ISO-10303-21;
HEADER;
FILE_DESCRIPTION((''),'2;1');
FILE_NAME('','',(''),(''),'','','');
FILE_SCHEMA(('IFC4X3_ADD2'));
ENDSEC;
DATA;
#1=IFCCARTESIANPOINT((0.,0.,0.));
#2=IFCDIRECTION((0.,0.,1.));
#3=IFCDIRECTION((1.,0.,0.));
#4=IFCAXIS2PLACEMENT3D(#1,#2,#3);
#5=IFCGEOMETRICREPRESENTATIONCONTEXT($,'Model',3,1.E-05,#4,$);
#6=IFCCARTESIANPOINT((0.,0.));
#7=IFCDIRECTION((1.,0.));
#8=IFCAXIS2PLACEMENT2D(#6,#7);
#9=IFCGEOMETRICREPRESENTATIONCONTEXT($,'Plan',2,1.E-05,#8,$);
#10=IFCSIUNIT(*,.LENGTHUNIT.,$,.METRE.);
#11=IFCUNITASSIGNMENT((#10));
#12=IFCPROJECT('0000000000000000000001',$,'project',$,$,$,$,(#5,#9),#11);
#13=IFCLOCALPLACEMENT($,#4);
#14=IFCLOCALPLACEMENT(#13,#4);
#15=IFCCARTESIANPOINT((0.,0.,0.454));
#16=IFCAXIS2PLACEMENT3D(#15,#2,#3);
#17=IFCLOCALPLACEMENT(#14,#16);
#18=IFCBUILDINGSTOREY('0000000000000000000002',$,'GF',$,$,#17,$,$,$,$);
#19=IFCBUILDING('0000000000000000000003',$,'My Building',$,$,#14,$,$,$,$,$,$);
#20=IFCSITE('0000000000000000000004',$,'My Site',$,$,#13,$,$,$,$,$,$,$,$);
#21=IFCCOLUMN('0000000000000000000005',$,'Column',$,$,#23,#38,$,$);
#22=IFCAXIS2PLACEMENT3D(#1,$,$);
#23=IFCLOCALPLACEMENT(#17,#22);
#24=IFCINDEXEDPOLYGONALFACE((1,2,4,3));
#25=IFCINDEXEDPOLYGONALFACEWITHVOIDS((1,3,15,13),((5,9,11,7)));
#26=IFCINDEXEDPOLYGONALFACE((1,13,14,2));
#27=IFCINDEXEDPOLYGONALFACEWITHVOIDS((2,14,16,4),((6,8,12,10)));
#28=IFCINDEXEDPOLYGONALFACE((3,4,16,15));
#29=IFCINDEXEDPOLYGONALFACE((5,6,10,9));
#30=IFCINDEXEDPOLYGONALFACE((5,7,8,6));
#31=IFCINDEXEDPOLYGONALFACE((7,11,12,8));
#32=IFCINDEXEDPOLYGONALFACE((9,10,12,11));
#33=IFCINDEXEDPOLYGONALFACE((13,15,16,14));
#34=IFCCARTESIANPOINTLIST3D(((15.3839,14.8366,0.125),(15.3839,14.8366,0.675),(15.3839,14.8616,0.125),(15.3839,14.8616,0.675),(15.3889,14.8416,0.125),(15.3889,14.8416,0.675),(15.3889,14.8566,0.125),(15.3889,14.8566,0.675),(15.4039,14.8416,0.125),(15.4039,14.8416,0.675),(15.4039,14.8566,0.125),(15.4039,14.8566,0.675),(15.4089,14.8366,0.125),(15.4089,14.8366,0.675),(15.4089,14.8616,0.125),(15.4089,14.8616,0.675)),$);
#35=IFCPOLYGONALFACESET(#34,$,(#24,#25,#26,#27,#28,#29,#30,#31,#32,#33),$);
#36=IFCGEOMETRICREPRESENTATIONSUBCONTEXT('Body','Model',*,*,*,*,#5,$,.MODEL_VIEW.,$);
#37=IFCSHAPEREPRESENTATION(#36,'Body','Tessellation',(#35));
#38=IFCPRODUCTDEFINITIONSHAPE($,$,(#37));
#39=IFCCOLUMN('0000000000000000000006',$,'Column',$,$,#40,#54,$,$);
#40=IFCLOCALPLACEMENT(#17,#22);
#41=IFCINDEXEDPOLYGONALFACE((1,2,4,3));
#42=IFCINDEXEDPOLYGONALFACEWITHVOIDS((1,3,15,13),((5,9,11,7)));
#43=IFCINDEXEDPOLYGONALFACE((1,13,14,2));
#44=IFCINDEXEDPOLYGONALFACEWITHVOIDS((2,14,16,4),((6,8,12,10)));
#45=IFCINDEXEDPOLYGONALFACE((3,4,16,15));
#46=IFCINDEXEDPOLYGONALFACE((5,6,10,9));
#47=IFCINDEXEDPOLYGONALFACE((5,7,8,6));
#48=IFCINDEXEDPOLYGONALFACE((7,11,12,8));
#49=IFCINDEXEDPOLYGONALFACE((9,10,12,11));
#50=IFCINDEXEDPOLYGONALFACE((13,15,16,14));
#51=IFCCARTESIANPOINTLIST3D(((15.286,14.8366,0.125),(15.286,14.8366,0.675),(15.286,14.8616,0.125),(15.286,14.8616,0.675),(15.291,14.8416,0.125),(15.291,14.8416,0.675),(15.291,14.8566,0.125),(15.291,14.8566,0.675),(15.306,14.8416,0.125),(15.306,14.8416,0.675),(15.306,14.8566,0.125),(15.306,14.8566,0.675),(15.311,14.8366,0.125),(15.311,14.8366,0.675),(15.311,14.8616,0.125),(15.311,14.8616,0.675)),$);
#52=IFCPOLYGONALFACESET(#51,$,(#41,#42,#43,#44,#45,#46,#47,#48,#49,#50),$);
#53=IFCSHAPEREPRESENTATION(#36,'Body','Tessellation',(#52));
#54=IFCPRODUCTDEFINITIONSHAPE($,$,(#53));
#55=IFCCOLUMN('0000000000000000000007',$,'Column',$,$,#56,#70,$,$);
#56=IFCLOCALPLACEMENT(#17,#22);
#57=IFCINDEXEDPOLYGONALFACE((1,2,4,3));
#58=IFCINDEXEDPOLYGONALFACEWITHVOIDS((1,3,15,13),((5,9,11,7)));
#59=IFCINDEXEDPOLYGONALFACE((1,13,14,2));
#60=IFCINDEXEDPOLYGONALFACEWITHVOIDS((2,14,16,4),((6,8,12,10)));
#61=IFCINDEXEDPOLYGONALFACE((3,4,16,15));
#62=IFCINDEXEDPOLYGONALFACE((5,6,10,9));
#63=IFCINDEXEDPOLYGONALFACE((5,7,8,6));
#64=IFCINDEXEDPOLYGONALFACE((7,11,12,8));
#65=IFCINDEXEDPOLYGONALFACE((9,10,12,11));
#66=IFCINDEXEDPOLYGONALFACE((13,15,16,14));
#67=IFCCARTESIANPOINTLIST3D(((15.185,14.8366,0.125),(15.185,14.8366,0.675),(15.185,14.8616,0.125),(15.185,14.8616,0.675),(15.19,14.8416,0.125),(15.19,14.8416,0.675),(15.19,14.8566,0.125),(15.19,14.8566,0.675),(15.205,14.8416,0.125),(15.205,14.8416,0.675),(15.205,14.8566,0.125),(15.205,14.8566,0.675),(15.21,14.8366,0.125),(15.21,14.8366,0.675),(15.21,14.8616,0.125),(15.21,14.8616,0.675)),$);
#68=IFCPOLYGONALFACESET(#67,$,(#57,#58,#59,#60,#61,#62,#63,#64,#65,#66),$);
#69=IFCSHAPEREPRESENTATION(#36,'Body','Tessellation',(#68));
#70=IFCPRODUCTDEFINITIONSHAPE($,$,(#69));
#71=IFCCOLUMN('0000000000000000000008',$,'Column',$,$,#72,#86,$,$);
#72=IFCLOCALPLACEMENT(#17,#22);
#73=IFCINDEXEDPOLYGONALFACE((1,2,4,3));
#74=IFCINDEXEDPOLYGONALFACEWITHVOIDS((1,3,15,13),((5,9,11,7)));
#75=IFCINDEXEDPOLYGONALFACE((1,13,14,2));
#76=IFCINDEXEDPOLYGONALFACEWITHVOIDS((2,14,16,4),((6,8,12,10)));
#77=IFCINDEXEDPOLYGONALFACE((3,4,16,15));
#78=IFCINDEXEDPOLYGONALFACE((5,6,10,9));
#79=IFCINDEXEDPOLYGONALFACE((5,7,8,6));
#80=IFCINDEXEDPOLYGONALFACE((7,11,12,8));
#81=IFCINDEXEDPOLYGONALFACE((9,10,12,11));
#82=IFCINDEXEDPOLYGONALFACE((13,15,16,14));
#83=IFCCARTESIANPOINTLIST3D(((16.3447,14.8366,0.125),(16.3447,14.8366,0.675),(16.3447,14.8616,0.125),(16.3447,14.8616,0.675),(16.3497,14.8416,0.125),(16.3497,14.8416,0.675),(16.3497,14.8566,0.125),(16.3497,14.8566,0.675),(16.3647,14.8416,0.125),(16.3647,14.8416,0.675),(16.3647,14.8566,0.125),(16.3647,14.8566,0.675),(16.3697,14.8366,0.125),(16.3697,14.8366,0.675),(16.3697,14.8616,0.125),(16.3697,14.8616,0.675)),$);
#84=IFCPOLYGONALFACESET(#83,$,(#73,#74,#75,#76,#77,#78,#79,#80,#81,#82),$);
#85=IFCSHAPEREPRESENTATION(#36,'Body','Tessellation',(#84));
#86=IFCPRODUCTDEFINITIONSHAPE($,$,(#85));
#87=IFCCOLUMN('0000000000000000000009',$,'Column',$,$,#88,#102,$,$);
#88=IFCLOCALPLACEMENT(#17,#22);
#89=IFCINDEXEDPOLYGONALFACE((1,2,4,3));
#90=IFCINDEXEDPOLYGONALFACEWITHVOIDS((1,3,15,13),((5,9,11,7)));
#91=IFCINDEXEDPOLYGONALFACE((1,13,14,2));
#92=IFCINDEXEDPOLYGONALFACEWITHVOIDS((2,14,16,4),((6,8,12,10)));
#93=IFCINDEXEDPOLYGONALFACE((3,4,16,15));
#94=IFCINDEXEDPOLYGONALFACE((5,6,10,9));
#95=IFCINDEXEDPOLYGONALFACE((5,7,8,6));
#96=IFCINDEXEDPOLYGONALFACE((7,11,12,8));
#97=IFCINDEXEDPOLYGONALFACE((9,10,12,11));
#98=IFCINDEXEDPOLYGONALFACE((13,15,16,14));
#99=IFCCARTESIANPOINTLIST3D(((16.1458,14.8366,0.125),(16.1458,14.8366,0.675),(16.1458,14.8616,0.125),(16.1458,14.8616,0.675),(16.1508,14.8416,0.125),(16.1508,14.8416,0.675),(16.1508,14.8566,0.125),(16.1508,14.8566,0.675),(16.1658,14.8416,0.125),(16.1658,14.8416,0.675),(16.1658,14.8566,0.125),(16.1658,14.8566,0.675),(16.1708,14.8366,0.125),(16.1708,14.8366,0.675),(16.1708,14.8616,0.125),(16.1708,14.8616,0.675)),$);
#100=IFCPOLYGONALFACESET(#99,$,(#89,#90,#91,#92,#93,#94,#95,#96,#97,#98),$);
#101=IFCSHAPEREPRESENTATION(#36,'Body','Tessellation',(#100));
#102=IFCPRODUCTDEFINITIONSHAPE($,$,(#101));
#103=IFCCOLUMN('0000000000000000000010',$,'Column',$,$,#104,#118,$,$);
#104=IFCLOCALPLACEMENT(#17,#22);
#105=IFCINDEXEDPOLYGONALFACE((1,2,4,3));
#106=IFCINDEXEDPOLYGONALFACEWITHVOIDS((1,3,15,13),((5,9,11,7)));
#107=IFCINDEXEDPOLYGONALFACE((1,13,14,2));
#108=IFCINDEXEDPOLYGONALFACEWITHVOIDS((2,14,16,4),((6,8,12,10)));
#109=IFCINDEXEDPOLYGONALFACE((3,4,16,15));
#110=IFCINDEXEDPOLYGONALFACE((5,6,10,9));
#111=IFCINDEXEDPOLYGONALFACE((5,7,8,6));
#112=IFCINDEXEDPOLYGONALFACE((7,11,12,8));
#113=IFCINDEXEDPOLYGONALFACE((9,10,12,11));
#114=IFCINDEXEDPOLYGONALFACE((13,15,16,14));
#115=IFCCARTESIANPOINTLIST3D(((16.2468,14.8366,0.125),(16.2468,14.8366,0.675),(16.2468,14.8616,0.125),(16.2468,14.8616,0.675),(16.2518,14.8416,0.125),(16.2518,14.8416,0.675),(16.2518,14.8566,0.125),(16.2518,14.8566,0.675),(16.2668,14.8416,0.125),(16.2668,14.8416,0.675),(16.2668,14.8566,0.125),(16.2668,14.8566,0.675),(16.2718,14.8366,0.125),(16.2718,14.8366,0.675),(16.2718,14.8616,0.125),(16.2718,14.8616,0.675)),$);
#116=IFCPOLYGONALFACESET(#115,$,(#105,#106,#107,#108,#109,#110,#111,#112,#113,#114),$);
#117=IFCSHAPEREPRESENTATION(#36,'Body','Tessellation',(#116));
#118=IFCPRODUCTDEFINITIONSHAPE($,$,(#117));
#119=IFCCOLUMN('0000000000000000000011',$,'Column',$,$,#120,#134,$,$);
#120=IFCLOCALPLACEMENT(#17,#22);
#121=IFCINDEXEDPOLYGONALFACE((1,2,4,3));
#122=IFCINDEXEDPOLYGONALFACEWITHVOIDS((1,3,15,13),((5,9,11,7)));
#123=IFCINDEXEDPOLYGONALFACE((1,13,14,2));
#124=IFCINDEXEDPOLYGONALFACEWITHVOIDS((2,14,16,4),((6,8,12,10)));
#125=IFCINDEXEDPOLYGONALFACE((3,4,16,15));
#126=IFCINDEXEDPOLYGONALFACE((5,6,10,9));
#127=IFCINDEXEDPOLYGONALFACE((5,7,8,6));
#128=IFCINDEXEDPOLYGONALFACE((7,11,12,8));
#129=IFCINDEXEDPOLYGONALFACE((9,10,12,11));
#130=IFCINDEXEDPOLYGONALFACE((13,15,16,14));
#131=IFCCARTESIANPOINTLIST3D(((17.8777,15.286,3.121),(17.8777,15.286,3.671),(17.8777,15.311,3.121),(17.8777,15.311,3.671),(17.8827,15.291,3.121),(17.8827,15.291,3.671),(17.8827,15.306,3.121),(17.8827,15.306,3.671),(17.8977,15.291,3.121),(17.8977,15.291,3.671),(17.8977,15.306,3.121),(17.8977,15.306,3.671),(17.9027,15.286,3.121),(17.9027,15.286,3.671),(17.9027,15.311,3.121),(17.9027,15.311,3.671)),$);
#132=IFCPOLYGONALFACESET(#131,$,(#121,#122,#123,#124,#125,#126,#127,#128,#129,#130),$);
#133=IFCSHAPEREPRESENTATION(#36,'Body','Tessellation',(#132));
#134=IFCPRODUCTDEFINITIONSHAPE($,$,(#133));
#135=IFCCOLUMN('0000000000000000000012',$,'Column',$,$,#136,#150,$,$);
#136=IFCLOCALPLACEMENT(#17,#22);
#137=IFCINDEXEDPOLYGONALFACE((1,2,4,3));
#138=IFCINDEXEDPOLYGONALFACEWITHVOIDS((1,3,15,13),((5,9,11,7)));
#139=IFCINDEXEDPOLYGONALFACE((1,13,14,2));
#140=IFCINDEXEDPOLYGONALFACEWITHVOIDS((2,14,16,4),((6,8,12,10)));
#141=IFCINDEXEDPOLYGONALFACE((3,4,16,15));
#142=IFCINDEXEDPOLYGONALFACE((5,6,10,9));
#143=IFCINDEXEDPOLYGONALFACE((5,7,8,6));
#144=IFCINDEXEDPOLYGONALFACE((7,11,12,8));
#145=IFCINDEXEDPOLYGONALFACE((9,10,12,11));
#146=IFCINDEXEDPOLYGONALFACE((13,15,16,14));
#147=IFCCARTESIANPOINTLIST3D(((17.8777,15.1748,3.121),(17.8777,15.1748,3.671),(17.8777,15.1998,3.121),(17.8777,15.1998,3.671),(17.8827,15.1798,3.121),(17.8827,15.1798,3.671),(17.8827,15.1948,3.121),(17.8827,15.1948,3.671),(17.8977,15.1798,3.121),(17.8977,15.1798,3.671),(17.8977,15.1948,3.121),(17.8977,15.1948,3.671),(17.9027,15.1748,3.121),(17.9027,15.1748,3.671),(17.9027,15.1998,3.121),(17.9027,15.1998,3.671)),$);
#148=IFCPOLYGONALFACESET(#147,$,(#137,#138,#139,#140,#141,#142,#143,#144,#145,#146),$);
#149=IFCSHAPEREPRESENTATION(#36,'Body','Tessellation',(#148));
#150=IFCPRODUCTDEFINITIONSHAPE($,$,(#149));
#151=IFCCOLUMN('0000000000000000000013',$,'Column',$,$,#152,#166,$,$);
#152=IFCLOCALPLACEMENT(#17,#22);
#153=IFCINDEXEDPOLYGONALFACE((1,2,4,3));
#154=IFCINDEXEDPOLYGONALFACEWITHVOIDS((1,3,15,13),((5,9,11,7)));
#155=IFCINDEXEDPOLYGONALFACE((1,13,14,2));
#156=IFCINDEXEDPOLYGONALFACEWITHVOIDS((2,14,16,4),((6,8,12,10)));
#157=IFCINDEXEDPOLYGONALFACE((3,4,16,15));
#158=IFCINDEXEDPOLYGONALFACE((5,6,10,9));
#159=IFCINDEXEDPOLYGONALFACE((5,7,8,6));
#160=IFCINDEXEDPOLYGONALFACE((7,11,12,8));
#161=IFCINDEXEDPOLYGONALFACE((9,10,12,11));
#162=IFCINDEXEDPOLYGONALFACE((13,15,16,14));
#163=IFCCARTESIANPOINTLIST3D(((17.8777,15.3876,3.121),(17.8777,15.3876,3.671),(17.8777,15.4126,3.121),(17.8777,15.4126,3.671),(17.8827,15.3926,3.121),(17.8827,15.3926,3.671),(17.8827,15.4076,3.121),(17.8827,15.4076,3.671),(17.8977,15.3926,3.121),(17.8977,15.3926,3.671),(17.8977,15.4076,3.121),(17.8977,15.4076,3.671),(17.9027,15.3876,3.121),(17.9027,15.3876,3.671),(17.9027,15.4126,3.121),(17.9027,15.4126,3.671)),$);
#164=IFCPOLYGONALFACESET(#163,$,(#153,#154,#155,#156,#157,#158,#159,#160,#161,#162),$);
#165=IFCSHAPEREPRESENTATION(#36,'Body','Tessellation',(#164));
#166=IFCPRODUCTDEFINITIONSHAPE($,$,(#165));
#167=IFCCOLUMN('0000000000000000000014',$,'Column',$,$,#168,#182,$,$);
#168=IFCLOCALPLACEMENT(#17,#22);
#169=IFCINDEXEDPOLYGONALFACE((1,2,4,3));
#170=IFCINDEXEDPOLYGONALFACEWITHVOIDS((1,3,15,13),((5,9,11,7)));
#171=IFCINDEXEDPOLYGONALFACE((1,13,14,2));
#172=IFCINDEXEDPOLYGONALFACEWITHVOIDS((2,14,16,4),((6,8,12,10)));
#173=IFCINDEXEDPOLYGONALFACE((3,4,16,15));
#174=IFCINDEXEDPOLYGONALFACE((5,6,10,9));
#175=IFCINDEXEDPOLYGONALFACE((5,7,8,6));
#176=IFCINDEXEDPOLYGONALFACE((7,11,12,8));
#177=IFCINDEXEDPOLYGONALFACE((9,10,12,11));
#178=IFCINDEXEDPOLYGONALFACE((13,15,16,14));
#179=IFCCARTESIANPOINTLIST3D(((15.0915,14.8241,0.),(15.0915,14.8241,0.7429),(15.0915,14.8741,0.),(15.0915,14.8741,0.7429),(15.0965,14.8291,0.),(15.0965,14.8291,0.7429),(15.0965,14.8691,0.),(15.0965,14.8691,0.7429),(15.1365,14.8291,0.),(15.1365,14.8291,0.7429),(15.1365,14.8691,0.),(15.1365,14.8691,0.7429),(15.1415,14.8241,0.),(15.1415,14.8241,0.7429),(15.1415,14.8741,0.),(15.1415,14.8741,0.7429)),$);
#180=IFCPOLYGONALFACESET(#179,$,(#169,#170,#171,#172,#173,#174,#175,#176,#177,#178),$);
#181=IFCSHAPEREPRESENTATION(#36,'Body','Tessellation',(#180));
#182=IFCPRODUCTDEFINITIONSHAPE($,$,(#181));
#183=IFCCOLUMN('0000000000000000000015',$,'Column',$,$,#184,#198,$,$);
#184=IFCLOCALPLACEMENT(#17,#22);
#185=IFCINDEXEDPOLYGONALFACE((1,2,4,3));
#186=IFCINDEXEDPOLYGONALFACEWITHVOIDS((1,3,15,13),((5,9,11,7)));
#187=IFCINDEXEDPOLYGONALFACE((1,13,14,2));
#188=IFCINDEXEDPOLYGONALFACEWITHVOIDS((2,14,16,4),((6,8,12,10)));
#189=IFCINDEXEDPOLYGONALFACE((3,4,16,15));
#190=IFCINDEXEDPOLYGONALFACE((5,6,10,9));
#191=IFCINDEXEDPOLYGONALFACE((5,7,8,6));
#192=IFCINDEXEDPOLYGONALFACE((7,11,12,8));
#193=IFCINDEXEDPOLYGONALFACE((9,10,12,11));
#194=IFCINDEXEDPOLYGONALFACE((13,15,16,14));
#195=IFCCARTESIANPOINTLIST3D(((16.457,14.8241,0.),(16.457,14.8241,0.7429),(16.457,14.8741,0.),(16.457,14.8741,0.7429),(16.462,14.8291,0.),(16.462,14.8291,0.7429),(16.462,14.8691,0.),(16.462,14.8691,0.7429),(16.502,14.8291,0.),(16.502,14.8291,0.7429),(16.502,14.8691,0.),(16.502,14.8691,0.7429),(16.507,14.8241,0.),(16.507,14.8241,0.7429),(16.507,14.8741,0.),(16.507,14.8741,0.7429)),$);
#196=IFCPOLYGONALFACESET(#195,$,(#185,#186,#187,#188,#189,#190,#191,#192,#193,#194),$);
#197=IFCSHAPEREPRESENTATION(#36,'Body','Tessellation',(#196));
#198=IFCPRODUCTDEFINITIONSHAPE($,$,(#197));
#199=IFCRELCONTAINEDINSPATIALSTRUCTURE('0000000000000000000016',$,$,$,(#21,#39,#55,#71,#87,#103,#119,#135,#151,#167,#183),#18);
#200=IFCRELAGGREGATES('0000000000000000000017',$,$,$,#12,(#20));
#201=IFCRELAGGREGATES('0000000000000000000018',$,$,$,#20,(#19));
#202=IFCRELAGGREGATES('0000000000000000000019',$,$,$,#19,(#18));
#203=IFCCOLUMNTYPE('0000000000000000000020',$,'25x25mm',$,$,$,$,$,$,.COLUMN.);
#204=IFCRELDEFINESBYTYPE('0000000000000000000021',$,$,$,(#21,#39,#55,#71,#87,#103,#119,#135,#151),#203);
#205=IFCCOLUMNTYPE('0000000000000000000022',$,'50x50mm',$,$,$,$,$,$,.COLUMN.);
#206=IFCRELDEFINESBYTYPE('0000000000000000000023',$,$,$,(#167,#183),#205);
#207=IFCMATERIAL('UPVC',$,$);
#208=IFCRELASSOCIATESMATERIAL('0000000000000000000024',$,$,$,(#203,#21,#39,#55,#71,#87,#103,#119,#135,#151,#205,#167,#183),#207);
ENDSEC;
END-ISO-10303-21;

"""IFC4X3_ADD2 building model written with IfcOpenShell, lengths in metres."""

from ifc_helpers import new_model, si_unit, frame, origin_with_axes, origin_2d_with_axis, place, context, subcontext, project, spatial, hollow_rectangle, extrude, material, material_profile, profile_set, profile_usage, type_object, element, save


model = new_model("IFC4X3_ADD2")

# Units and contexts
model_context = context("Model", 3, precision=1e-05, world=origin_with_axes())
plan_context = context("Plan", 2, precision=1e-05, world=origin_2d_with_axis())
body_context = subcontext(model_context, "Body", "Model", "MODEL_VIEW")
ifc_project = project(units=[si_unit("LENGTHUNIT", "METRE")], contexts=[model_context, plan_context])

# Site, building, storey
site_placement = place(None, origin_with_axes())
site = spatial("IfcSite", under=ifc_project, at=site_placement, Name="My Site")
building_placement = place(site_placement, origin_with_axes())
building = spatial("IfcBuilding", under=site, at=building_placement, Name="My Building")
storey_placement = place(building_placement, frame((0.0, 0.0, 0.454), z_axis=(0.0, 0.0, 1.0), x_axis=(1.0, 0.0, 0.0)))
storey = spatial("IfcBuildingStorey", under=building, at=storey_placement, Name="GF")

# Columns
ifc_material_1 = material(Name="UPVC")
ifc_material_profile_1 = material_profile(ifc_material_1, hollow_rectangle(XDim=0.025, YDim=0.025, WallThickness=0.005))
ifc_profile_set_1 = profile_set([ifc_material_profile_1])
ifc_profile_usage_1 = profile_usage(ifc_profile_set_1)
column_type_1 = type_object("IfcColumnType", Name="25x25mm", PredefinedType="COLUMN", material=ifc_profile_set_1)
column_1_placement = place(storey_placement, frame((15.3964, 14.8491, 0.125), z_axis=(0.0, 0.0, 1.0), x_axis=(0.0, -1.0, 0.0)))
element("IfcColumn", 1, at=column_1_placement, inside=storey, type_object=column_type_1, material=ifc_profile_usage_1, Name="Column", context=body_context, shape_type="SweptSolid", body=[
    extrude(hollow_rectangle(XDim=0.025, YDim=0.025, WallThickness=0.005), origin_with_axes(), (0.0, 0.0, 1.0), 0.55),
])
ifc_profile_usage_2 = profile_usage(ifc_profile_set_1)
column_2_placement = place(storey_placement, frame((15.2985, 14.8491, 0.125), z_axis=(0.0, 0.0, 1.0), x_axis=(0.0, -1.0, 0.0)))
element("IfcColumn", 2, at=column_2_placement, inside=storey, type_object=column_type_1, material=ifc_profile_usage_2, Name="Column", context=body_context, shape_type="SweptSolid", body=[
    extrude(hollow_rectangle(XDim=0.025, YDim=0.025, WallThickness=0.005), origin_with_axes(), (0.0, 0.0, 1.0), 0.55),
])
ifc_profile_usage_3 = profile_usage(ifc_profile_set_1)
column_3_placement = place(storey_placement, frame((15.1975, 14.8491, 0.125), z_axis=(0.0, 0.0, 1.0), x_axis=(0.0, -1.0, 0.0)))
element("IfcColumn", 3, at=column_3_placement, inside=storey, type_object=column_type_1, material=ifc_profile_usage_3, Name="Column", context=body_context, shape_type="SweptSolid", body=[
    extrude(hollow_rectangle(XDim=0.025, YDim=0.025, WallThickness=0.005), origin_with_axes(), (0.0, 0.0, 1.0), 0.55),
])
ifc_profile_usage_4 = profile_usage(ifc_profile_set_1)
column_4_placement = place(storey_placement, frame((16.3572, 14.8491, 0.125), z_axis=(0.0, 0.0, 1.0), x_axis=(0.0, -1.0, 0.0)))
element("IfcColumn", 4, at=column_4_placement, inside=storey, type_object=column_type_1, material=ifc_profile_usage_4, Name="Column", context=body_context, shape_type="SweptSolid", body=[
    extrude(hollow_rectangle(XDim=0.025, YDim=0.025, WallThickness=0.005), origin_with_axes(), (0.0, 0.0, 1.0), 0.55),
])
ifc_profile_usage_5 = profile_usage(ifc_profile_set_1)
column_5_placement = place(storey_placement, frame((16.1583, 14.8491, 0.125), z_axis=(0.0, 0.0, 1.0), x_axis=(0.0, -1.0, 0.0)))
element("IfcColumn", 5, at=column_5_placement, inside=storey, type_object=column_type_1, material=ifc_profile_usage_5, Name="Column", context=body_context, shape_type="SweptSolid", body=[
    extrude(hollow_rectangle(XDim=0.025, YDim=0.025, WallThickness=0.005), origin_with_axes(), (0.0, 0.0, 1.0), 0.55),
])
ifc_profile_usage_6 = profile_usage(ifc_profile_set_1)
column_6_placement = place(storey_placement, frame((16.2593, 14.8491, 0.125), z_axis=(0.0, 0.0, 1.0), x_axis=(0.0, -1.0, 0.0)))
element("IfcColumn", 6, at=column_6_placement, inside=storey, type_object=column_type_1, material=ifc_profile_usage_6, Name="Column", context=body_context, shape_type="SweptSolid", body=[
    extrude(hollow_rectangle(XDim=0.025, YDim=0.025, WallThickness=0.005), origin_with_axes(), (0.0, 0.0, 1.0), 0.55),
])
ifc_profile_usage_7 = profile_usage(ifc_profile_set_1)
column_7_placement = place(storey_placement, frame((17.8902, 15.2985, 3.121), z_axis=(0.0, 0.0, 1.0), x_axis=(0.0, -1.0, 0.0)))
element("IfcColumn", 7, at=column_7_placement, inside=storey, type_object=column_type_1, material=ifc_profile_usage_7, Name="Column", context=body_context, shape_type="SweptSolid", body=[
    extrude(hollow_rectangle(XDim=0.025, YDim=0.025, WallThickness=0.005), origin_with_axes(), (0.0, 0.0, 1.0), 0.55),
])
ifc_profile_usage_8 = profile_usage(ifc_profile_set_1)
column_8_placement = place(storey_placement, frame((17.8902, 15.1873, 3.121), z_axis=(0.0, 0.0, 1.0), x_axis=(0.0, -1.0, 0.0)))
element("IfcColumn", 8, at=column_8_placement, inside=storey, type_object=column_type_1, material=ifc_profile_usage_8, Name="Column", context=body_context, shape_type="SweptSolid", body=[
    extrude(hollow_rectangle(XDim=0.025, YDim=0.025, WallThickness=0.005), origin_with_axes(), (0.0, 0.0, 1.0), 0.55),
])
ifc_profile_usage_9 = profile_usage(ifc_profile_set_1)
column_9_placement = place(storey_placement, frame((17.8902, 15.4001, 3.121), z_axis=(0.0, 0.0, 1.0), x_axis=(0.0, -1.0, 0.0)))
element("IfcColumn", 9, at=column_9_placement, inside=storey, type_object=column_type_1, material=ifc_profile_usage_9, Name="Column", context=body_context, shape_type="SweptSolid", body=[
    extrude(hollow_rectangle(XDim=0.025, YDim=0.025, WallThickness=0.005), origin_with_axes(), (0.0, 0.0, 1.0), 0.55),
])
ifc_material_profile_2 = material_profile(ifc_material_1, hollow_rectangle(XDim=0.05, YDim=0.05, WallThickness=0.005))
ifc_profile_set_2 = profile_set([ifc_material_profile_2])
ifc_profile_usage_10 = profile_usage(ifc_profile_set_2)
column_type_2 = type_object("IfcColumnType", Name="50x50mm", PredefinedType="COLUMN", material=ifc_profile_set_2)
column_10_placement = place(storey_placement, frame((15.1165, 14.8491, 0.0), z_axis=(0.0, 0.0, 1.0), x_axis=(1.0, 0.0, 0.0)))
element("IfcColumn", 10, at=column_10_placement, inside=storey, type_object=column_type_2, material=ifc_profile_usage_10, Name="Column", context=body_context, shape_type="SweptSolid", body=[
    extrude(hollow_rectangle(XDim=0.05, YDim=0.05, WallThickness=0.005), origin_with_axes(), (0.0, 0.0, 1.0), 0.7429),
])
ifc_profile_usage_11 = profile_usage(ifc_profile_set_2)
column_11_placement = place(storey_placement, frame((16.482, 14.8491, 0.0), z_axis=(0.0, 0.0, 1.0), x_axis=(1.0, 0.0, 0.0)))
element("IfcColumn", 11, at=column_11_placement, inside=storey, type_object=column_type_2, material=ifc_profile_usage_11, Name="Column", context=body_context, shape_type="SweptSolid", body=[
    extrude(hollow_rectangle(XDim=0.05, YDim=0.05, WallThickness=0.005), origin_with_axes(), (0.0, 0.0, 1.0), 0.7429),
])

save(model, "model.ifc")
